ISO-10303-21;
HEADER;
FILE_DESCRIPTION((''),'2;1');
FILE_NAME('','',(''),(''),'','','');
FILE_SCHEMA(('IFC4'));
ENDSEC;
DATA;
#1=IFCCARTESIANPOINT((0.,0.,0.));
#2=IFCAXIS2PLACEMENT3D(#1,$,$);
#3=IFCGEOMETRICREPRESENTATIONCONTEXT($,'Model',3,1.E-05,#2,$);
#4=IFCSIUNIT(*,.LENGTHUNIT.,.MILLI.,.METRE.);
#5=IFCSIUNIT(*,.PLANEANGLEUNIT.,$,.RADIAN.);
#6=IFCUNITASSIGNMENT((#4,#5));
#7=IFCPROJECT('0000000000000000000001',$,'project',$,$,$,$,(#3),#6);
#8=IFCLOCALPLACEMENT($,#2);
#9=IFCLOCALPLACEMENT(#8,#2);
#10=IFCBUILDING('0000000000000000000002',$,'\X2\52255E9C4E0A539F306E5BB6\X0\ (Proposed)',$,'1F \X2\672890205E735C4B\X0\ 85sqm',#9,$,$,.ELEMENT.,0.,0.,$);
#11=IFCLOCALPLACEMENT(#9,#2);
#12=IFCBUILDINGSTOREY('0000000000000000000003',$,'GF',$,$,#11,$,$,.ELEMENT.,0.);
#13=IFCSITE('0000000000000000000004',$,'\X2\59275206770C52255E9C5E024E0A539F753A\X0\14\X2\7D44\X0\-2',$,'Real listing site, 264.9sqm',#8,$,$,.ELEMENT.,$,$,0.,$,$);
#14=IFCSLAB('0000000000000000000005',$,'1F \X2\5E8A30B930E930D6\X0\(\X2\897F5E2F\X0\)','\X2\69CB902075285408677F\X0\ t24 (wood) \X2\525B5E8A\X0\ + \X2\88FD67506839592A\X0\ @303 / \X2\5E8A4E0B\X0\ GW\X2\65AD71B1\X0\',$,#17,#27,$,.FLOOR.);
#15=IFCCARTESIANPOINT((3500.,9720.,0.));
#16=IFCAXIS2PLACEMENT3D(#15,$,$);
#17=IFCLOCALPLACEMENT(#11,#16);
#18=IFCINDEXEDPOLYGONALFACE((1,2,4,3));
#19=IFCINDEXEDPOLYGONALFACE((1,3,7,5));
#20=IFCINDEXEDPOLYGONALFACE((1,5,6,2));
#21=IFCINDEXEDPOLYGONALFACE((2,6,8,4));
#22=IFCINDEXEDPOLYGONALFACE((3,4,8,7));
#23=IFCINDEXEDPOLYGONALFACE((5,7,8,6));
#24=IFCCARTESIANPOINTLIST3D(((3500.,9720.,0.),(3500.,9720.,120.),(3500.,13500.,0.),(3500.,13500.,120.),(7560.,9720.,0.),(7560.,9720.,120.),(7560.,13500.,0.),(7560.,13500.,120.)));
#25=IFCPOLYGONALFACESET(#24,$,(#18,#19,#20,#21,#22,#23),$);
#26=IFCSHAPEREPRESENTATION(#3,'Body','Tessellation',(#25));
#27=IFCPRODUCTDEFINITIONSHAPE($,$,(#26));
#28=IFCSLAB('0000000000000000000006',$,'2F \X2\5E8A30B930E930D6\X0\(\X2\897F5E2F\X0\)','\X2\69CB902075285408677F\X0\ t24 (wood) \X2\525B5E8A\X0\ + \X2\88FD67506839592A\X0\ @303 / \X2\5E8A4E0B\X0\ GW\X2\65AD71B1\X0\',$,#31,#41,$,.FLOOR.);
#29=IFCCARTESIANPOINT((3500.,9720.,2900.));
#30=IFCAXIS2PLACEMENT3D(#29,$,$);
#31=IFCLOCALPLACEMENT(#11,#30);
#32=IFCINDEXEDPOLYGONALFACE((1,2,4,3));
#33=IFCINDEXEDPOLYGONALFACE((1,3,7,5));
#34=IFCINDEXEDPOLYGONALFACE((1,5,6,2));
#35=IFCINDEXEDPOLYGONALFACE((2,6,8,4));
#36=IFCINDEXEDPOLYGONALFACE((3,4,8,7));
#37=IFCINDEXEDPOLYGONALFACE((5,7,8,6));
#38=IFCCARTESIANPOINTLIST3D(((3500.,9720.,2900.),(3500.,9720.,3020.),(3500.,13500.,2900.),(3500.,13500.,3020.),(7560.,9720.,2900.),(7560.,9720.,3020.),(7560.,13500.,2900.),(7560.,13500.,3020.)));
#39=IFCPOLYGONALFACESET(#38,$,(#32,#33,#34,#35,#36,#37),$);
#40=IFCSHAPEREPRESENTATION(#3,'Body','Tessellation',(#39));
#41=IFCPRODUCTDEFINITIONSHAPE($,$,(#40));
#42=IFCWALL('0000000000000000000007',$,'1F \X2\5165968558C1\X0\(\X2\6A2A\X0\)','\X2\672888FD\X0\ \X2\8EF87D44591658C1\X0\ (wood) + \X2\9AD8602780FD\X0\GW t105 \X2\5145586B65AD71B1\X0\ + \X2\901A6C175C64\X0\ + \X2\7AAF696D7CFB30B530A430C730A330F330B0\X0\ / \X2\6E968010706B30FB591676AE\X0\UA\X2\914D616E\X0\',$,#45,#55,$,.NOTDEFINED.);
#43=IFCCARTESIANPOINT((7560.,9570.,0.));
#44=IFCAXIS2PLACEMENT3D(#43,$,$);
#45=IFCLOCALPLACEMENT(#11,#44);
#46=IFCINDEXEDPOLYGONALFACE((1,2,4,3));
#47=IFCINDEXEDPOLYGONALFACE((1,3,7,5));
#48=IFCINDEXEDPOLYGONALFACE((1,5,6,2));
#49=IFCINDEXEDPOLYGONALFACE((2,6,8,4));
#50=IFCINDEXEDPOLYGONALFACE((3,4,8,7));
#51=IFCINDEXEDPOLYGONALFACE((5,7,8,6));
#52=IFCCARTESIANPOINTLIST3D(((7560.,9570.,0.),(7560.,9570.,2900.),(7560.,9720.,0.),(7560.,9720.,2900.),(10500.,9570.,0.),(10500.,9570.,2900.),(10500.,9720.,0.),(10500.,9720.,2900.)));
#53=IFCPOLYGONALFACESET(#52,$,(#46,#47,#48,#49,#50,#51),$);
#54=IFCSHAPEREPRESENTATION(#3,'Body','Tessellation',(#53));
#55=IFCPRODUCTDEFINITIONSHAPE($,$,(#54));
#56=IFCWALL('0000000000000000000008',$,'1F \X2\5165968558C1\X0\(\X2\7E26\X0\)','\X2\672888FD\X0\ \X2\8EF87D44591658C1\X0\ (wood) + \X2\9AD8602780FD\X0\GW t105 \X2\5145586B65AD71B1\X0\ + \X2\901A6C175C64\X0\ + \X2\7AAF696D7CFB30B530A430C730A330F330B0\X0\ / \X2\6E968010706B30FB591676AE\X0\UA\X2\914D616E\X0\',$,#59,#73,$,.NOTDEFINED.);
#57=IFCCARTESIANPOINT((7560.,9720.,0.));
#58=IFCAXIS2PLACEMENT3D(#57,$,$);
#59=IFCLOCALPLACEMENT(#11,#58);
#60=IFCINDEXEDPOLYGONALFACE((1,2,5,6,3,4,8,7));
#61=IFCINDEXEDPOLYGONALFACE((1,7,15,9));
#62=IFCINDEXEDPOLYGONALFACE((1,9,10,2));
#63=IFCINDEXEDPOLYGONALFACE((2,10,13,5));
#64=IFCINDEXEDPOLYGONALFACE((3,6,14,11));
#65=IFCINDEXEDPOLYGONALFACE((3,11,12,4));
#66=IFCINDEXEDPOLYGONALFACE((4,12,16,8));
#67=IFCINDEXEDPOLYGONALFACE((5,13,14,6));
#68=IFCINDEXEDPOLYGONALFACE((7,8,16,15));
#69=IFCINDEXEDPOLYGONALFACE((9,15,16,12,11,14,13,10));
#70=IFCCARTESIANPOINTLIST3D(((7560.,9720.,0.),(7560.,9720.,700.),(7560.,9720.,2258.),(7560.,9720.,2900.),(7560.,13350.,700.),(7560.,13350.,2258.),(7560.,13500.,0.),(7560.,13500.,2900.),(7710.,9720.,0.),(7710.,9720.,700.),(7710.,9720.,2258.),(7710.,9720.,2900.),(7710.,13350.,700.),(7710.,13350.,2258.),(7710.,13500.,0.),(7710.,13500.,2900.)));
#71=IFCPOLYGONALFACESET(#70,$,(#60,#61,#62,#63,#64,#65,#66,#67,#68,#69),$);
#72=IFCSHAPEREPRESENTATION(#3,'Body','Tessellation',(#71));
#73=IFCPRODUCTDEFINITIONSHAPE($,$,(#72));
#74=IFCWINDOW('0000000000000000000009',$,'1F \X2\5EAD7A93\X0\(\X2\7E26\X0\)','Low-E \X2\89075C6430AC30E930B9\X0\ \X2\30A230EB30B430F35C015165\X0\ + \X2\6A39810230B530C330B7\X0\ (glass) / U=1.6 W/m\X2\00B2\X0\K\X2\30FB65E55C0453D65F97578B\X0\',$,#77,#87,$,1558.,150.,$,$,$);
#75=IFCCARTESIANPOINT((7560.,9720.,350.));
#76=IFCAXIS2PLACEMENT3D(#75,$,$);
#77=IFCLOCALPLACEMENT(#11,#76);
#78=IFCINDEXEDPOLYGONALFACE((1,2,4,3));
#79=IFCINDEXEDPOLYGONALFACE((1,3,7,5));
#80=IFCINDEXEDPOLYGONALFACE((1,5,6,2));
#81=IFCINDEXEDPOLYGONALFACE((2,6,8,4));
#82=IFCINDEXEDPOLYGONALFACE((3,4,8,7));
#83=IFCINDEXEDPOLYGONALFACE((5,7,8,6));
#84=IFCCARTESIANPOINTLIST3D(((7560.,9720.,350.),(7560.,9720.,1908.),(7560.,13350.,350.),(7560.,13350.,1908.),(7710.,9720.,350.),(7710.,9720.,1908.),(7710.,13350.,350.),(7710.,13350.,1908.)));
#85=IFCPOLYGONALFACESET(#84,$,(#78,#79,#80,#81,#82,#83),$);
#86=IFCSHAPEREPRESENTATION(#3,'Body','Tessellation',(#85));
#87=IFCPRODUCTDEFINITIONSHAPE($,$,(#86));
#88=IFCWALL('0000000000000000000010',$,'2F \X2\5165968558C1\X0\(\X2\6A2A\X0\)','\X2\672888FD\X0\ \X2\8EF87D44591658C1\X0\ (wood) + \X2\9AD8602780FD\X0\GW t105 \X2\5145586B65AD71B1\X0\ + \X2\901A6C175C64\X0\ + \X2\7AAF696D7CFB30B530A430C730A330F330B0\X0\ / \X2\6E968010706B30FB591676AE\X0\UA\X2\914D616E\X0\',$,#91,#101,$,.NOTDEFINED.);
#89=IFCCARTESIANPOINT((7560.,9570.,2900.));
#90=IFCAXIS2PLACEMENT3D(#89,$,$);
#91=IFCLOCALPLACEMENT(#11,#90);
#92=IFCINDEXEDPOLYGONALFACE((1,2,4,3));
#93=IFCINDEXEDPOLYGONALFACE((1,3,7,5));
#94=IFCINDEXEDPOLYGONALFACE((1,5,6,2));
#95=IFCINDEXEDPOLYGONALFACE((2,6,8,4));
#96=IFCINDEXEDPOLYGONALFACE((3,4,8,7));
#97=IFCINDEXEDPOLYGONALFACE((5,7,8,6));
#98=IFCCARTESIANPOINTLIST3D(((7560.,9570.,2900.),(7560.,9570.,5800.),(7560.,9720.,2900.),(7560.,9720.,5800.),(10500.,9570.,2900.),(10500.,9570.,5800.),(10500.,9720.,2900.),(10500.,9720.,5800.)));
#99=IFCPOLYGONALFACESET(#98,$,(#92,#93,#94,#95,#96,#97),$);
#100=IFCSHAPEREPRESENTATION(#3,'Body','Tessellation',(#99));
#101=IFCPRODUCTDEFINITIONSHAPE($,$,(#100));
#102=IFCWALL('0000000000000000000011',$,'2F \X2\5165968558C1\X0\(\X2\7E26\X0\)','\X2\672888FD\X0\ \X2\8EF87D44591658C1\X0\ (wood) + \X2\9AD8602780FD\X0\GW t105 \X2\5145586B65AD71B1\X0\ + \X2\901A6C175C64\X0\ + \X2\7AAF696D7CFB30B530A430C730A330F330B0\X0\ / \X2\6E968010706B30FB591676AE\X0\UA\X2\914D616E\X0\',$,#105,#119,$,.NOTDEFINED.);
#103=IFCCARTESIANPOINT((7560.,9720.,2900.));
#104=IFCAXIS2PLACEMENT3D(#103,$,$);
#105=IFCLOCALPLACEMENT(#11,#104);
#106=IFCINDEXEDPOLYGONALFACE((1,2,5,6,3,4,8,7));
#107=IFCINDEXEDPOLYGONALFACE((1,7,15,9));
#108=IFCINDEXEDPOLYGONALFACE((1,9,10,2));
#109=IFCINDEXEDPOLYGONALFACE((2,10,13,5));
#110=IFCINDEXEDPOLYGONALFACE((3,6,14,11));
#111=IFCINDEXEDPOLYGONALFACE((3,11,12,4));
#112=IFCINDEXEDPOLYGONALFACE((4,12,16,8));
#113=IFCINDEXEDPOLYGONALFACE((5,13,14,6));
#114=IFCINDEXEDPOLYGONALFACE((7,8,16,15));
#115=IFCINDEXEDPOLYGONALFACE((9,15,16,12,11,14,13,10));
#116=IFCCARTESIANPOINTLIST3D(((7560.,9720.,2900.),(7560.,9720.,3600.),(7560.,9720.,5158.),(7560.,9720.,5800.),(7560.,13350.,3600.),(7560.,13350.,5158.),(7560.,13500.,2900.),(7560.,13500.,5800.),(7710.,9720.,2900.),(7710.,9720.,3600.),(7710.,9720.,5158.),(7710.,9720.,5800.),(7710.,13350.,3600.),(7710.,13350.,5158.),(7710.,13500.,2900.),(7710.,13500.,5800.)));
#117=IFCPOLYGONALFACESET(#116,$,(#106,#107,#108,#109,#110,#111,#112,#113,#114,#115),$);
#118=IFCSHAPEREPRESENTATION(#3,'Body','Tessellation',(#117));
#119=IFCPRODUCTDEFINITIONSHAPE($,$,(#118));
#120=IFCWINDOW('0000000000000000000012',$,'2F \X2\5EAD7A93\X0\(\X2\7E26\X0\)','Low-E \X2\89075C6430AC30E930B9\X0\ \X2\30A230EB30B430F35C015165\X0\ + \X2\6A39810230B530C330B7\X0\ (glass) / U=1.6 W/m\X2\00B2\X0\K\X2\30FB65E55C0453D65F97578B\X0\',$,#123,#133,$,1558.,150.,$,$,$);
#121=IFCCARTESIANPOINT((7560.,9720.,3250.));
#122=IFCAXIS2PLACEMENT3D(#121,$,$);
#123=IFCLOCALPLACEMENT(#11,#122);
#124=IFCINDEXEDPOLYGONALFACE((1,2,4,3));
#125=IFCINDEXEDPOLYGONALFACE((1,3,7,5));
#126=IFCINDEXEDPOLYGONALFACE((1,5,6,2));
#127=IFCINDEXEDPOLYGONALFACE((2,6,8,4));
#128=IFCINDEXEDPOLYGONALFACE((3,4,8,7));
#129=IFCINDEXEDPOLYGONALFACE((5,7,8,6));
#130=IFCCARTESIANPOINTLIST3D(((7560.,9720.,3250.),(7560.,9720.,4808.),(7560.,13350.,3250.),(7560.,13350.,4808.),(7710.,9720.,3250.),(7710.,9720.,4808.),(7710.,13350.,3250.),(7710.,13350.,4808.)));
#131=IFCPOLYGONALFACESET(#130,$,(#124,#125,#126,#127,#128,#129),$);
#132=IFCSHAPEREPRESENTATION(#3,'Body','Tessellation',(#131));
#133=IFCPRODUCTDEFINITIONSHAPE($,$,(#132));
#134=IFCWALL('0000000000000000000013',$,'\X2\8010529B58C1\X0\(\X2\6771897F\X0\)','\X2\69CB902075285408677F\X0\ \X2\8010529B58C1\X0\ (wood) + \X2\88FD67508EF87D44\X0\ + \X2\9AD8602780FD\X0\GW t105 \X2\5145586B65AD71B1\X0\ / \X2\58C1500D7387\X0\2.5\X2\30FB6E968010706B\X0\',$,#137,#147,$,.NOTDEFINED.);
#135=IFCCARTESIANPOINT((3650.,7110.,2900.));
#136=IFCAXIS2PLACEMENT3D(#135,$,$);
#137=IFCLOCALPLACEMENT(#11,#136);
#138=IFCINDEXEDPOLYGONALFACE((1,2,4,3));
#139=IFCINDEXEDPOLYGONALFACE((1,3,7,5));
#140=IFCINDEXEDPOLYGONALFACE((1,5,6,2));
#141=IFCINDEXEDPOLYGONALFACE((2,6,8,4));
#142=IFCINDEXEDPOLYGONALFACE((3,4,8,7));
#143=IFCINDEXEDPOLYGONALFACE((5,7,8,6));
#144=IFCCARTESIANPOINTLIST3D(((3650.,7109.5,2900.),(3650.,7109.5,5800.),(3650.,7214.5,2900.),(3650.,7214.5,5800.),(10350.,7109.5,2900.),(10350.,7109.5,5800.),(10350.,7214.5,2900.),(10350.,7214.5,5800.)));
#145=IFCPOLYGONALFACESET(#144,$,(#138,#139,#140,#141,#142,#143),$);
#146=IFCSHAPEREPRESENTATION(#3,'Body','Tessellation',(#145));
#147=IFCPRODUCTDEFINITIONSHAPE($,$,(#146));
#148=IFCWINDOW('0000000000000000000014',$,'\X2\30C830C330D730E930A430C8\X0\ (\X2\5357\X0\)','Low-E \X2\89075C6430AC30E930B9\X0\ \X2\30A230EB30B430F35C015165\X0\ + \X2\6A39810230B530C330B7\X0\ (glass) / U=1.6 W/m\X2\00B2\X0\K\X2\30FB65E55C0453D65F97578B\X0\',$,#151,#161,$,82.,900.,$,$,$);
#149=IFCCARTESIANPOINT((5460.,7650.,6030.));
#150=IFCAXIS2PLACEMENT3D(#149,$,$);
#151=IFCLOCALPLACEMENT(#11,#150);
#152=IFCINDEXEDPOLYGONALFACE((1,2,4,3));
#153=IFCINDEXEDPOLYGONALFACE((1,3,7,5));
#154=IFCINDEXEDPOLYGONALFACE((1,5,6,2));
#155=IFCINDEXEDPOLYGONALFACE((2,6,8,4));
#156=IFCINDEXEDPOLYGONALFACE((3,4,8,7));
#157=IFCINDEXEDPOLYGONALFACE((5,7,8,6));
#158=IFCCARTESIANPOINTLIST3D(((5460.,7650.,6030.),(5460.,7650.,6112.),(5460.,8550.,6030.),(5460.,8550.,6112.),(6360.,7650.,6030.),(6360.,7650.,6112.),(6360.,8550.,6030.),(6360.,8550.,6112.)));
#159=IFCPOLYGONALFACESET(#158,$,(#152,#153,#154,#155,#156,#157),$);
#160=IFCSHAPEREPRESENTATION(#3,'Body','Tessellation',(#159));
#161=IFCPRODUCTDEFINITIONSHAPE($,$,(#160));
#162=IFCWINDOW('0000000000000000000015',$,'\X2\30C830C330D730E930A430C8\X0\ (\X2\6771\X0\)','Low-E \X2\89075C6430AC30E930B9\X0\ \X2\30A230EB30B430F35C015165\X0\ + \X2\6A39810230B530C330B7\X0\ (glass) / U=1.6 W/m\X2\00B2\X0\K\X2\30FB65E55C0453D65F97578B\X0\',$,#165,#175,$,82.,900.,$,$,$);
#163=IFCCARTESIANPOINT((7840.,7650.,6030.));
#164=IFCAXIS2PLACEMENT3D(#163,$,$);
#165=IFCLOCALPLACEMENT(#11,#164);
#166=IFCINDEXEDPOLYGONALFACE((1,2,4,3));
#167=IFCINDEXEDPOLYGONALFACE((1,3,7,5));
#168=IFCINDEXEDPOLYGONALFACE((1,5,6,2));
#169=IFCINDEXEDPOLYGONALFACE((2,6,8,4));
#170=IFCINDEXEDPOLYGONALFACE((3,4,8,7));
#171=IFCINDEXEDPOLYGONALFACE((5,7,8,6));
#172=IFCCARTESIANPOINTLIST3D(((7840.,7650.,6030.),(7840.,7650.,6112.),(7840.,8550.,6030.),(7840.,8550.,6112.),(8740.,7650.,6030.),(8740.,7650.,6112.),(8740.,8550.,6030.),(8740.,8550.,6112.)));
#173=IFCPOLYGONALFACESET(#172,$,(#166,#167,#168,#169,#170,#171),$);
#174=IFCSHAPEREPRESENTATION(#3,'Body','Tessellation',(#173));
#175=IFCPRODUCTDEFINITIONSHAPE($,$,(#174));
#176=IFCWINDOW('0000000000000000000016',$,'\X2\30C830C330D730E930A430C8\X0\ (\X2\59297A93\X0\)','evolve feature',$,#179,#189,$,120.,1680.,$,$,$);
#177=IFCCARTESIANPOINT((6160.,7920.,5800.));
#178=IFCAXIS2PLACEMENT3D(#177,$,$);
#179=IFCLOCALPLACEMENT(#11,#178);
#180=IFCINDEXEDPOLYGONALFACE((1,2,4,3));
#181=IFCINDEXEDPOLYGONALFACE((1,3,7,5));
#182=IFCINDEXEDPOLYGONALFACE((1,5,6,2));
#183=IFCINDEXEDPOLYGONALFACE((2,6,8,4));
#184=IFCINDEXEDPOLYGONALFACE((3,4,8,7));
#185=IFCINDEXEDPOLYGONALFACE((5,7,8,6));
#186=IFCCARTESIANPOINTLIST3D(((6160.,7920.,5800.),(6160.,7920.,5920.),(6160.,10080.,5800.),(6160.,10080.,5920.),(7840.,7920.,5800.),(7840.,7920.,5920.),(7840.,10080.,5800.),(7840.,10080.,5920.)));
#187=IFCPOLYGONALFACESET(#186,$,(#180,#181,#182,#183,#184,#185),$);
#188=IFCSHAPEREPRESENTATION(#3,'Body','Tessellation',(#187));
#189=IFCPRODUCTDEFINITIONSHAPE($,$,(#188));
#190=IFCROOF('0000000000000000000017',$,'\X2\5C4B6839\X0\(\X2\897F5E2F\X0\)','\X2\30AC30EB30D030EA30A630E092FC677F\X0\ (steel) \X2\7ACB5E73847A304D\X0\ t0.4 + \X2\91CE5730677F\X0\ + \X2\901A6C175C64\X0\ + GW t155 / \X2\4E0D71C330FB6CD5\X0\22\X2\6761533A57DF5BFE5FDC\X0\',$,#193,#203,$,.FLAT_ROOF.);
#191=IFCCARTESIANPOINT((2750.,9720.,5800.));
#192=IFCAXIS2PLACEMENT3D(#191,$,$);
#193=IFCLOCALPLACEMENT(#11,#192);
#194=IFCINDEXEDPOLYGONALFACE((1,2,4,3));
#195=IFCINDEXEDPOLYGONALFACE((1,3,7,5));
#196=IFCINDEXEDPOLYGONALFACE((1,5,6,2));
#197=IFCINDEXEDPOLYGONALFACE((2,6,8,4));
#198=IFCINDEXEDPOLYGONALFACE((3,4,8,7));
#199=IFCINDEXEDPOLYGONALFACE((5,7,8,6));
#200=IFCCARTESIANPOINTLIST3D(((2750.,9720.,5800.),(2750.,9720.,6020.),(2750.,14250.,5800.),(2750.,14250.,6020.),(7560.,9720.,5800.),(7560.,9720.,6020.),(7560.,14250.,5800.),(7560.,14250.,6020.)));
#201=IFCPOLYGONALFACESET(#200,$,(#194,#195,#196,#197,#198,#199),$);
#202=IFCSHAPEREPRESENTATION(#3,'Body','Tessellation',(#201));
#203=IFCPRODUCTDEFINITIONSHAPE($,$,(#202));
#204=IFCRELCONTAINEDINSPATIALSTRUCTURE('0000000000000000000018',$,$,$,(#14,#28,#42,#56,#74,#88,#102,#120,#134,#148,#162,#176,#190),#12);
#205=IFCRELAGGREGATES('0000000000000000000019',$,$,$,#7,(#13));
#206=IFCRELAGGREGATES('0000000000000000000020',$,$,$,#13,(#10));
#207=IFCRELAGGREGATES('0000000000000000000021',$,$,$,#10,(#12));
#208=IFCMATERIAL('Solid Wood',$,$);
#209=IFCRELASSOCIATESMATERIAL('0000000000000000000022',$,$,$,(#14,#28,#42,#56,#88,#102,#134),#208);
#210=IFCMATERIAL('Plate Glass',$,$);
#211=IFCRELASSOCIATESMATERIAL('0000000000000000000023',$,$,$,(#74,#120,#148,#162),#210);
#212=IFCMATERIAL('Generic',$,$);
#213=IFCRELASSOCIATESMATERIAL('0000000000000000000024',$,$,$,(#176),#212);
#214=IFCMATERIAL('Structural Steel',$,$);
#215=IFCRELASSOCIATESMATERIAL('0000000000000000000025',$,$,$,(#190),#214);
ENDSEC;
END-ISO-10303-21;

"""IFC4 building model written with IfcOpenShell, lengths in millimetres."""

from ifc_helpers import new_model, si_unit, frame, frame_2d, origin, place, context, project, spatial, rectangle, extrude, material, element, fill, save


model = new_model("IFC4")

# Units and contexts
model_context = context("Model", 3, precision=1e-05, world=origin())
ifc_project = project(units=[si_unit("LENGTHUNIT", "METRE", prefix="MILLI"), si_unit("PLANEANGLEUNIT", "RADIAN")], contexts=[model_context])

# Site, building, storey
site_placement = place(None, origin())
site = spatial("IfcSite", under=ifc_project, at=site_placement, Name="大分県別府市上原町14組-2", ObjectType="Real listing site, 264.9sqm", CompositionType="ELEMENT", RefElevation=0.0)
building_placement = place(site_placement, origin())
building = spatial("IfcBuilding", under=site, at=building_placement, Name="別府上原の家 (Proposed)", ObjectType="1F 木造平屋 85sqm", CompositionType="ELEMENT", ElevationOfRefHeight=0.0, ElevationOfTerrain=0.0)
storey_placement = place(building_placement, origin())
storey = spatial("IfcBuildingStorey", under=building, at=storey_placement, Name="GF", CompositionType="ELEMENT", Elevation=0.0)

# Slabs
ifc_material_1 = material(Name="Solid Wood")
slab_1_placement = place(storey_placement, frame((3500.0, 9720.0, 0.0)))
element("IfcSlab", 1, at=slab_1_placement, inside=storey, material=ifc_material_1, Name="1F 床スラブ(西帯)", Description="構造用合板 t24 (wood) 剛床 + 製材根太 @303 / 床下 GW断熱", PredefinedType="FLOOR", context=model_context, shape_type="SweptSolid", body=[
    extrude(rectangle(XDim=4060.0, YDim=3780.0, at=frame_2d((2030.0, 1890.0))), frame((3500.0, 9720.0, 0.0)), (0.0, 0.0, 1.0), 120.0),
])
slab_2_placement = place(storey_placement, frame((3500.0, 9720.0, 2900.0)))
element("IfcSlab", 2, at=slab_2_placement, inside=storey, material=ifc_material_1, Name="2F 床スラブ(西帯)", Description="構造用合板 t24 (wood) 剛床 + 製材根太 @303 / 床下 GW断熱", PredefinedType="FLOOR", context=model_context, shape_type="SweptSolid", body=[
    extrude(rectangle(XDim=4060.0, YDim=3780.0, at=frame_2d((2030.0, 1890.0))), frame((3500.0, 9720.0, 2900.0)), (0.0, 0.0, 1.0), 120.0),
])

# Wall
wall_1_placement = place(storey_placement, frame((7560.0, 9570.0, 0.0)))
element("IfcWall", 3, at=wall_1_placement, inside=storey, material=ifc_material_1, Name="1F 入隅壁(横)", Description="木製 軸組外壁 (wood) + 高性能GW t105 充填断熱 + 通気層 + 窯業系サイディング / 準耐火・外皮UA配慮", PredefinedType="NOTDEFINED", context=model_context, shape_type="SweptSolid", body=[
    extrude(rectangle(XDim=2940.0, YDim=150.0, at=frame_2d((1470.0, 75.0))), frame((7560.0, 9570.0, 0.0)), (0.0, 0.0, 1.0), 2900.0),
])

# Wall, opening, window
wall_2_placement = place(storey_placement, frame((7560.0, 9720.0, 0.0)))
wall_2 = element("IfcWall", 4, at=wall_2_placement, inside=storey, material=ifc_material_1, Name="1F 入隅壁(縦)", Description="木製 軸組外壁 (wood) + 高性能GW t105 充填断熱 + 通気層 + 窯業系サイディング / 準耐火・外皮UA配慮", PredefinedType="NOTDEFINED", context=model_context, shape_type="SweptSolid", body=[
    extrude(rectangle(XDim=150.0, YDim=3780.0, at=frame_2d((75.0, 1890.0))), frame((7560.0, 9720.0, 0.0)), (0.0, 0.0, 1.0), 2900.0),
])
opening_1_placement = place(storey_placement, frame((7560.0, 9720.0, 350.0)))
opening_1 = element("IfcOpeningElement", 5, at=opening_1_placement, cuts=wall_2, PredefinedType="NOTDEFINED", context=model_context, shape_type="SweptSolid", body=[
    extrude(rectangle(XDim=150.0, YDim=3630.0, at=frame_2d((75.0, 1815.0))), frame((7560.0, 9720.0, 350.0)), (0.0, 0.0, 1.0), 1558.0),
])
ifc_material_2 = material(Name="Plate Glass")
window_1_placement = place(storey_placement, frame((7560.0, 9720.0, 350.0)))
window_1 = element("IfcWindow", 6, at=window_1_placement, inside=storey, material=ifc_material_2, Name="1F 庭窓(縦)", Description="Low-E 複層ガラス アルゴン封入 + 樹脂サッシ (glass) / U=1.6 W/m²K・日射取得型", OverallHeight=1558.0, OverallWidth=150.0, context=model_context, shape_type="SweptSolid", body=[
    extrude(rectangle(XDim=150.0, YDim=3630.0, at=frame_2d((75.0, 1815.0))), frame((7560.0, 9720.0, 350.0)), (0.0, 0.0, 1.0), 1558.0),
])
fill(opening_1, window_1)

# Wall
wall_3_placement = place(storey_placement, frame((7560.0, 9570.0, 2900.0)))
element("IfcWall", 7, at=wall_3_placement, inside=storey, material=ifc_material_1, Name="2F 入隅壁(横)", Description="木製 軸組外壁 (wood) + 高性能GW t105 充填断熱 + 通気層 + 窯業系サイディング / 準耐火・外皮UA配慮", PredefinedType="NOTDEFINED", context=model_context, shape_type="SweptSolid", body=[
    extrude(rectangle(XDim=2940.0, YDim=150.0, at=frame_2d((1470.0, 75.0))), frame((7560.0, 9570.0, 2900.0)), (0.0, 0.0, 1.0), 2900.0),
])

# Wall, opening, window
wall_4_placement = place(storey_placement, frame((7560.0, 9720.0, 2900.0)))
wall_4 = element("IfcWall", 8, at=wall_4_placement, inside=storey, material=ifc_material_1, Name="2F 入隅壁(縦)", Description="木製 軸組外壁 (wood) + 高性能GW t105 充填断熱 + 通気層 + 窯業系サイディング / 準耐火・外皮UA配慮", PredefinedType="NOTDEFINED", context=model_context, shape_type="SweptSolid", body=[
    extrude(rectangle(XDim=150.0, YDim=3780.0, at=frame_2d((75.0, 1890.0))), frame((7560.0, 9720.0, 2900.0)), (0.0, 0.0, 1.0), 2900.0),
])
opening_2_placement = place(storey_placement, frame((7560.0, 9720.0, 3250.0)))
opening_2 = element("IfcOpeningElement", 9, at=opening_2_placement, cuts=wall_4, PredefinedType="NOTDEFINED", context=model_context, shape_type="SweptSolid", body=[
    extrude(rectangle(XDim=150.0, YDim=3630.0, at=frame_2d((75.0, 1815.0))), frame((7560.0, 9720.0, 3250.0)), (0.0, 0.0, 1.0), 1558.0),
])
window_2_placement = place(storey_placement, frame((7560.0, 9720.0, 3250.0)))
window_2 = element("IfcWindow", 10, at=window_2_placement, inside=storey, material=ifc_material_2, Name="2F 庭窓(縦)", Description="Low-E 複層ガラス アルゴン封入 + 樹脂サッシ (glass) / U=1.6 W/m²K・日射取得型", OverallHeight=1558.0, OverallWidth=150.0, context=model_context, shape_type="SweptSolid", body=[
    extrude(rectangle(XDim=150.0, YDim=3630.0, at=frame_2d((75.0, 1815.0))), frame((7560.0, 9720.0, 3250.0)), (0.0, 0.0, 1.0), 1558.0),
])
fill(opening_2, window_2)

# Wall
wall_5_placement = place(storey_placement, frame((3650.0, 7110.0, 2900.0)))
element("IfcWall", 11, at=wall_5_placement, inside=storey, material=ifc_material_1, Name="耐力壁(東西)", Description="構造用合板 耐力壁 (wood) + 製材軸組 + 高性能GW t105 充填断熱 / 壁倍率2.5・準耐火", PredefinedType="NOTDEFINED", context=model_context, shape_type="SweptSolid", body=[
    extrude(rectangle(XDim=6700.0, YDim=105.0, at=frame_2d((3350.0, 52.0))), frame((3650.0, 7110.0, 2900.0)), (0.0, 0.0, 1.0), 2900.0),
])

# Windows
window_3_placement = place(storey_placement, frame((5460.0, 7650.0, 6030.0)))
element("IfcWindow", 12, at=window_3_placement, inside=storey, material=ifc_material_2, Name="トップライト (南)", Description="Low-E 複層ガラス アルゴン封入 + 樹脂サッシ (glass) / U=1.6 W/m²K・日射取得型", OverallHeight=82.0, OverallWidth=900.0, context=model_context, shape_type="SweptSolid", body=[
    extrude(rectangle(XDim=900.0, YDim=900.0, at=frame_2d((450.0, 450.0))), frame((5460.0, 7650.0, 6030.0)), (0.0, 0.0, 1.0), 82.0),
])
window_4_placement = place(storey_placement, frame((7840.0, 7650.0, 6030.0)))
element("IfcWindow", 13, at=window_4_placement, inside=storey, material=ifc_material_2, Name="トップライト (東)", Description="Low-E 複層ガラス アルゴン封入 + 樹脂サッシ (glass) / U=1.6 W/m²K・日射取得型", OverallHeight=82.0, OverallWidth=900.0, context=model_context, shape_type="SweptSolid", body=[
    extrude(rectangle(XDim=900.0, YDim=900.0, at=frame_2d((450.0, 450.0))), frame((7840.0, 7650.0, 6030.0)), (0.0, 0.0, 1.0), 82.0),
])
ifc_material_3 = material(Name="Generic")
window_5_placement = place(storey_placement, frame((6160.0, 7920.0, 5800.0)))
element("IfcWindow", 14, at=window_5_placement, inside=storey, material=ifc_material_3, Name="トップライト (天窓)", Description="evolve feature", OverallHeight=120.0, OverallWidth=1680.0, context=model_context, shape_type="SweptSolid", body=[
    extrude(rectangle(XDim=1680.0, YDim=2160.0, at=frame_2d((840.0, 1080.0))), frame((6160.0, 7920.0, 5800.0)), (0.0, 0.0, 1.0), 120.0),
])

# Roof
ifc_material_4 = material(Name="Structural Steel")
for number, where, name in (
    (15, (2750.0, 9720.0, 5800.0), "屋根(西帯)"),
):
    element("IfcRoof", number, at=place(storey_placement, frame(where)), inside=storey, material=ifc_material_4, Name=name, Description="ガルバリウム鋼板 (steel) 立平葺き t0.4 + 野地板 + 通気層 + GW t155 / 不燃・法22条区域対応", PredefinedType="FLAT_ROOF", context=model_context, shape_type="SweptSolid", body=[
        extrude(rectangle(XDim=4810.0, YDim=4530.0, at=frame_2d((2405.0, 2265.0))), frame((2750.0, 9720.0, 5800.0)), (0.0, 0.0, 1.0), 220.0),
    ])

save(model, "model.ifc")
